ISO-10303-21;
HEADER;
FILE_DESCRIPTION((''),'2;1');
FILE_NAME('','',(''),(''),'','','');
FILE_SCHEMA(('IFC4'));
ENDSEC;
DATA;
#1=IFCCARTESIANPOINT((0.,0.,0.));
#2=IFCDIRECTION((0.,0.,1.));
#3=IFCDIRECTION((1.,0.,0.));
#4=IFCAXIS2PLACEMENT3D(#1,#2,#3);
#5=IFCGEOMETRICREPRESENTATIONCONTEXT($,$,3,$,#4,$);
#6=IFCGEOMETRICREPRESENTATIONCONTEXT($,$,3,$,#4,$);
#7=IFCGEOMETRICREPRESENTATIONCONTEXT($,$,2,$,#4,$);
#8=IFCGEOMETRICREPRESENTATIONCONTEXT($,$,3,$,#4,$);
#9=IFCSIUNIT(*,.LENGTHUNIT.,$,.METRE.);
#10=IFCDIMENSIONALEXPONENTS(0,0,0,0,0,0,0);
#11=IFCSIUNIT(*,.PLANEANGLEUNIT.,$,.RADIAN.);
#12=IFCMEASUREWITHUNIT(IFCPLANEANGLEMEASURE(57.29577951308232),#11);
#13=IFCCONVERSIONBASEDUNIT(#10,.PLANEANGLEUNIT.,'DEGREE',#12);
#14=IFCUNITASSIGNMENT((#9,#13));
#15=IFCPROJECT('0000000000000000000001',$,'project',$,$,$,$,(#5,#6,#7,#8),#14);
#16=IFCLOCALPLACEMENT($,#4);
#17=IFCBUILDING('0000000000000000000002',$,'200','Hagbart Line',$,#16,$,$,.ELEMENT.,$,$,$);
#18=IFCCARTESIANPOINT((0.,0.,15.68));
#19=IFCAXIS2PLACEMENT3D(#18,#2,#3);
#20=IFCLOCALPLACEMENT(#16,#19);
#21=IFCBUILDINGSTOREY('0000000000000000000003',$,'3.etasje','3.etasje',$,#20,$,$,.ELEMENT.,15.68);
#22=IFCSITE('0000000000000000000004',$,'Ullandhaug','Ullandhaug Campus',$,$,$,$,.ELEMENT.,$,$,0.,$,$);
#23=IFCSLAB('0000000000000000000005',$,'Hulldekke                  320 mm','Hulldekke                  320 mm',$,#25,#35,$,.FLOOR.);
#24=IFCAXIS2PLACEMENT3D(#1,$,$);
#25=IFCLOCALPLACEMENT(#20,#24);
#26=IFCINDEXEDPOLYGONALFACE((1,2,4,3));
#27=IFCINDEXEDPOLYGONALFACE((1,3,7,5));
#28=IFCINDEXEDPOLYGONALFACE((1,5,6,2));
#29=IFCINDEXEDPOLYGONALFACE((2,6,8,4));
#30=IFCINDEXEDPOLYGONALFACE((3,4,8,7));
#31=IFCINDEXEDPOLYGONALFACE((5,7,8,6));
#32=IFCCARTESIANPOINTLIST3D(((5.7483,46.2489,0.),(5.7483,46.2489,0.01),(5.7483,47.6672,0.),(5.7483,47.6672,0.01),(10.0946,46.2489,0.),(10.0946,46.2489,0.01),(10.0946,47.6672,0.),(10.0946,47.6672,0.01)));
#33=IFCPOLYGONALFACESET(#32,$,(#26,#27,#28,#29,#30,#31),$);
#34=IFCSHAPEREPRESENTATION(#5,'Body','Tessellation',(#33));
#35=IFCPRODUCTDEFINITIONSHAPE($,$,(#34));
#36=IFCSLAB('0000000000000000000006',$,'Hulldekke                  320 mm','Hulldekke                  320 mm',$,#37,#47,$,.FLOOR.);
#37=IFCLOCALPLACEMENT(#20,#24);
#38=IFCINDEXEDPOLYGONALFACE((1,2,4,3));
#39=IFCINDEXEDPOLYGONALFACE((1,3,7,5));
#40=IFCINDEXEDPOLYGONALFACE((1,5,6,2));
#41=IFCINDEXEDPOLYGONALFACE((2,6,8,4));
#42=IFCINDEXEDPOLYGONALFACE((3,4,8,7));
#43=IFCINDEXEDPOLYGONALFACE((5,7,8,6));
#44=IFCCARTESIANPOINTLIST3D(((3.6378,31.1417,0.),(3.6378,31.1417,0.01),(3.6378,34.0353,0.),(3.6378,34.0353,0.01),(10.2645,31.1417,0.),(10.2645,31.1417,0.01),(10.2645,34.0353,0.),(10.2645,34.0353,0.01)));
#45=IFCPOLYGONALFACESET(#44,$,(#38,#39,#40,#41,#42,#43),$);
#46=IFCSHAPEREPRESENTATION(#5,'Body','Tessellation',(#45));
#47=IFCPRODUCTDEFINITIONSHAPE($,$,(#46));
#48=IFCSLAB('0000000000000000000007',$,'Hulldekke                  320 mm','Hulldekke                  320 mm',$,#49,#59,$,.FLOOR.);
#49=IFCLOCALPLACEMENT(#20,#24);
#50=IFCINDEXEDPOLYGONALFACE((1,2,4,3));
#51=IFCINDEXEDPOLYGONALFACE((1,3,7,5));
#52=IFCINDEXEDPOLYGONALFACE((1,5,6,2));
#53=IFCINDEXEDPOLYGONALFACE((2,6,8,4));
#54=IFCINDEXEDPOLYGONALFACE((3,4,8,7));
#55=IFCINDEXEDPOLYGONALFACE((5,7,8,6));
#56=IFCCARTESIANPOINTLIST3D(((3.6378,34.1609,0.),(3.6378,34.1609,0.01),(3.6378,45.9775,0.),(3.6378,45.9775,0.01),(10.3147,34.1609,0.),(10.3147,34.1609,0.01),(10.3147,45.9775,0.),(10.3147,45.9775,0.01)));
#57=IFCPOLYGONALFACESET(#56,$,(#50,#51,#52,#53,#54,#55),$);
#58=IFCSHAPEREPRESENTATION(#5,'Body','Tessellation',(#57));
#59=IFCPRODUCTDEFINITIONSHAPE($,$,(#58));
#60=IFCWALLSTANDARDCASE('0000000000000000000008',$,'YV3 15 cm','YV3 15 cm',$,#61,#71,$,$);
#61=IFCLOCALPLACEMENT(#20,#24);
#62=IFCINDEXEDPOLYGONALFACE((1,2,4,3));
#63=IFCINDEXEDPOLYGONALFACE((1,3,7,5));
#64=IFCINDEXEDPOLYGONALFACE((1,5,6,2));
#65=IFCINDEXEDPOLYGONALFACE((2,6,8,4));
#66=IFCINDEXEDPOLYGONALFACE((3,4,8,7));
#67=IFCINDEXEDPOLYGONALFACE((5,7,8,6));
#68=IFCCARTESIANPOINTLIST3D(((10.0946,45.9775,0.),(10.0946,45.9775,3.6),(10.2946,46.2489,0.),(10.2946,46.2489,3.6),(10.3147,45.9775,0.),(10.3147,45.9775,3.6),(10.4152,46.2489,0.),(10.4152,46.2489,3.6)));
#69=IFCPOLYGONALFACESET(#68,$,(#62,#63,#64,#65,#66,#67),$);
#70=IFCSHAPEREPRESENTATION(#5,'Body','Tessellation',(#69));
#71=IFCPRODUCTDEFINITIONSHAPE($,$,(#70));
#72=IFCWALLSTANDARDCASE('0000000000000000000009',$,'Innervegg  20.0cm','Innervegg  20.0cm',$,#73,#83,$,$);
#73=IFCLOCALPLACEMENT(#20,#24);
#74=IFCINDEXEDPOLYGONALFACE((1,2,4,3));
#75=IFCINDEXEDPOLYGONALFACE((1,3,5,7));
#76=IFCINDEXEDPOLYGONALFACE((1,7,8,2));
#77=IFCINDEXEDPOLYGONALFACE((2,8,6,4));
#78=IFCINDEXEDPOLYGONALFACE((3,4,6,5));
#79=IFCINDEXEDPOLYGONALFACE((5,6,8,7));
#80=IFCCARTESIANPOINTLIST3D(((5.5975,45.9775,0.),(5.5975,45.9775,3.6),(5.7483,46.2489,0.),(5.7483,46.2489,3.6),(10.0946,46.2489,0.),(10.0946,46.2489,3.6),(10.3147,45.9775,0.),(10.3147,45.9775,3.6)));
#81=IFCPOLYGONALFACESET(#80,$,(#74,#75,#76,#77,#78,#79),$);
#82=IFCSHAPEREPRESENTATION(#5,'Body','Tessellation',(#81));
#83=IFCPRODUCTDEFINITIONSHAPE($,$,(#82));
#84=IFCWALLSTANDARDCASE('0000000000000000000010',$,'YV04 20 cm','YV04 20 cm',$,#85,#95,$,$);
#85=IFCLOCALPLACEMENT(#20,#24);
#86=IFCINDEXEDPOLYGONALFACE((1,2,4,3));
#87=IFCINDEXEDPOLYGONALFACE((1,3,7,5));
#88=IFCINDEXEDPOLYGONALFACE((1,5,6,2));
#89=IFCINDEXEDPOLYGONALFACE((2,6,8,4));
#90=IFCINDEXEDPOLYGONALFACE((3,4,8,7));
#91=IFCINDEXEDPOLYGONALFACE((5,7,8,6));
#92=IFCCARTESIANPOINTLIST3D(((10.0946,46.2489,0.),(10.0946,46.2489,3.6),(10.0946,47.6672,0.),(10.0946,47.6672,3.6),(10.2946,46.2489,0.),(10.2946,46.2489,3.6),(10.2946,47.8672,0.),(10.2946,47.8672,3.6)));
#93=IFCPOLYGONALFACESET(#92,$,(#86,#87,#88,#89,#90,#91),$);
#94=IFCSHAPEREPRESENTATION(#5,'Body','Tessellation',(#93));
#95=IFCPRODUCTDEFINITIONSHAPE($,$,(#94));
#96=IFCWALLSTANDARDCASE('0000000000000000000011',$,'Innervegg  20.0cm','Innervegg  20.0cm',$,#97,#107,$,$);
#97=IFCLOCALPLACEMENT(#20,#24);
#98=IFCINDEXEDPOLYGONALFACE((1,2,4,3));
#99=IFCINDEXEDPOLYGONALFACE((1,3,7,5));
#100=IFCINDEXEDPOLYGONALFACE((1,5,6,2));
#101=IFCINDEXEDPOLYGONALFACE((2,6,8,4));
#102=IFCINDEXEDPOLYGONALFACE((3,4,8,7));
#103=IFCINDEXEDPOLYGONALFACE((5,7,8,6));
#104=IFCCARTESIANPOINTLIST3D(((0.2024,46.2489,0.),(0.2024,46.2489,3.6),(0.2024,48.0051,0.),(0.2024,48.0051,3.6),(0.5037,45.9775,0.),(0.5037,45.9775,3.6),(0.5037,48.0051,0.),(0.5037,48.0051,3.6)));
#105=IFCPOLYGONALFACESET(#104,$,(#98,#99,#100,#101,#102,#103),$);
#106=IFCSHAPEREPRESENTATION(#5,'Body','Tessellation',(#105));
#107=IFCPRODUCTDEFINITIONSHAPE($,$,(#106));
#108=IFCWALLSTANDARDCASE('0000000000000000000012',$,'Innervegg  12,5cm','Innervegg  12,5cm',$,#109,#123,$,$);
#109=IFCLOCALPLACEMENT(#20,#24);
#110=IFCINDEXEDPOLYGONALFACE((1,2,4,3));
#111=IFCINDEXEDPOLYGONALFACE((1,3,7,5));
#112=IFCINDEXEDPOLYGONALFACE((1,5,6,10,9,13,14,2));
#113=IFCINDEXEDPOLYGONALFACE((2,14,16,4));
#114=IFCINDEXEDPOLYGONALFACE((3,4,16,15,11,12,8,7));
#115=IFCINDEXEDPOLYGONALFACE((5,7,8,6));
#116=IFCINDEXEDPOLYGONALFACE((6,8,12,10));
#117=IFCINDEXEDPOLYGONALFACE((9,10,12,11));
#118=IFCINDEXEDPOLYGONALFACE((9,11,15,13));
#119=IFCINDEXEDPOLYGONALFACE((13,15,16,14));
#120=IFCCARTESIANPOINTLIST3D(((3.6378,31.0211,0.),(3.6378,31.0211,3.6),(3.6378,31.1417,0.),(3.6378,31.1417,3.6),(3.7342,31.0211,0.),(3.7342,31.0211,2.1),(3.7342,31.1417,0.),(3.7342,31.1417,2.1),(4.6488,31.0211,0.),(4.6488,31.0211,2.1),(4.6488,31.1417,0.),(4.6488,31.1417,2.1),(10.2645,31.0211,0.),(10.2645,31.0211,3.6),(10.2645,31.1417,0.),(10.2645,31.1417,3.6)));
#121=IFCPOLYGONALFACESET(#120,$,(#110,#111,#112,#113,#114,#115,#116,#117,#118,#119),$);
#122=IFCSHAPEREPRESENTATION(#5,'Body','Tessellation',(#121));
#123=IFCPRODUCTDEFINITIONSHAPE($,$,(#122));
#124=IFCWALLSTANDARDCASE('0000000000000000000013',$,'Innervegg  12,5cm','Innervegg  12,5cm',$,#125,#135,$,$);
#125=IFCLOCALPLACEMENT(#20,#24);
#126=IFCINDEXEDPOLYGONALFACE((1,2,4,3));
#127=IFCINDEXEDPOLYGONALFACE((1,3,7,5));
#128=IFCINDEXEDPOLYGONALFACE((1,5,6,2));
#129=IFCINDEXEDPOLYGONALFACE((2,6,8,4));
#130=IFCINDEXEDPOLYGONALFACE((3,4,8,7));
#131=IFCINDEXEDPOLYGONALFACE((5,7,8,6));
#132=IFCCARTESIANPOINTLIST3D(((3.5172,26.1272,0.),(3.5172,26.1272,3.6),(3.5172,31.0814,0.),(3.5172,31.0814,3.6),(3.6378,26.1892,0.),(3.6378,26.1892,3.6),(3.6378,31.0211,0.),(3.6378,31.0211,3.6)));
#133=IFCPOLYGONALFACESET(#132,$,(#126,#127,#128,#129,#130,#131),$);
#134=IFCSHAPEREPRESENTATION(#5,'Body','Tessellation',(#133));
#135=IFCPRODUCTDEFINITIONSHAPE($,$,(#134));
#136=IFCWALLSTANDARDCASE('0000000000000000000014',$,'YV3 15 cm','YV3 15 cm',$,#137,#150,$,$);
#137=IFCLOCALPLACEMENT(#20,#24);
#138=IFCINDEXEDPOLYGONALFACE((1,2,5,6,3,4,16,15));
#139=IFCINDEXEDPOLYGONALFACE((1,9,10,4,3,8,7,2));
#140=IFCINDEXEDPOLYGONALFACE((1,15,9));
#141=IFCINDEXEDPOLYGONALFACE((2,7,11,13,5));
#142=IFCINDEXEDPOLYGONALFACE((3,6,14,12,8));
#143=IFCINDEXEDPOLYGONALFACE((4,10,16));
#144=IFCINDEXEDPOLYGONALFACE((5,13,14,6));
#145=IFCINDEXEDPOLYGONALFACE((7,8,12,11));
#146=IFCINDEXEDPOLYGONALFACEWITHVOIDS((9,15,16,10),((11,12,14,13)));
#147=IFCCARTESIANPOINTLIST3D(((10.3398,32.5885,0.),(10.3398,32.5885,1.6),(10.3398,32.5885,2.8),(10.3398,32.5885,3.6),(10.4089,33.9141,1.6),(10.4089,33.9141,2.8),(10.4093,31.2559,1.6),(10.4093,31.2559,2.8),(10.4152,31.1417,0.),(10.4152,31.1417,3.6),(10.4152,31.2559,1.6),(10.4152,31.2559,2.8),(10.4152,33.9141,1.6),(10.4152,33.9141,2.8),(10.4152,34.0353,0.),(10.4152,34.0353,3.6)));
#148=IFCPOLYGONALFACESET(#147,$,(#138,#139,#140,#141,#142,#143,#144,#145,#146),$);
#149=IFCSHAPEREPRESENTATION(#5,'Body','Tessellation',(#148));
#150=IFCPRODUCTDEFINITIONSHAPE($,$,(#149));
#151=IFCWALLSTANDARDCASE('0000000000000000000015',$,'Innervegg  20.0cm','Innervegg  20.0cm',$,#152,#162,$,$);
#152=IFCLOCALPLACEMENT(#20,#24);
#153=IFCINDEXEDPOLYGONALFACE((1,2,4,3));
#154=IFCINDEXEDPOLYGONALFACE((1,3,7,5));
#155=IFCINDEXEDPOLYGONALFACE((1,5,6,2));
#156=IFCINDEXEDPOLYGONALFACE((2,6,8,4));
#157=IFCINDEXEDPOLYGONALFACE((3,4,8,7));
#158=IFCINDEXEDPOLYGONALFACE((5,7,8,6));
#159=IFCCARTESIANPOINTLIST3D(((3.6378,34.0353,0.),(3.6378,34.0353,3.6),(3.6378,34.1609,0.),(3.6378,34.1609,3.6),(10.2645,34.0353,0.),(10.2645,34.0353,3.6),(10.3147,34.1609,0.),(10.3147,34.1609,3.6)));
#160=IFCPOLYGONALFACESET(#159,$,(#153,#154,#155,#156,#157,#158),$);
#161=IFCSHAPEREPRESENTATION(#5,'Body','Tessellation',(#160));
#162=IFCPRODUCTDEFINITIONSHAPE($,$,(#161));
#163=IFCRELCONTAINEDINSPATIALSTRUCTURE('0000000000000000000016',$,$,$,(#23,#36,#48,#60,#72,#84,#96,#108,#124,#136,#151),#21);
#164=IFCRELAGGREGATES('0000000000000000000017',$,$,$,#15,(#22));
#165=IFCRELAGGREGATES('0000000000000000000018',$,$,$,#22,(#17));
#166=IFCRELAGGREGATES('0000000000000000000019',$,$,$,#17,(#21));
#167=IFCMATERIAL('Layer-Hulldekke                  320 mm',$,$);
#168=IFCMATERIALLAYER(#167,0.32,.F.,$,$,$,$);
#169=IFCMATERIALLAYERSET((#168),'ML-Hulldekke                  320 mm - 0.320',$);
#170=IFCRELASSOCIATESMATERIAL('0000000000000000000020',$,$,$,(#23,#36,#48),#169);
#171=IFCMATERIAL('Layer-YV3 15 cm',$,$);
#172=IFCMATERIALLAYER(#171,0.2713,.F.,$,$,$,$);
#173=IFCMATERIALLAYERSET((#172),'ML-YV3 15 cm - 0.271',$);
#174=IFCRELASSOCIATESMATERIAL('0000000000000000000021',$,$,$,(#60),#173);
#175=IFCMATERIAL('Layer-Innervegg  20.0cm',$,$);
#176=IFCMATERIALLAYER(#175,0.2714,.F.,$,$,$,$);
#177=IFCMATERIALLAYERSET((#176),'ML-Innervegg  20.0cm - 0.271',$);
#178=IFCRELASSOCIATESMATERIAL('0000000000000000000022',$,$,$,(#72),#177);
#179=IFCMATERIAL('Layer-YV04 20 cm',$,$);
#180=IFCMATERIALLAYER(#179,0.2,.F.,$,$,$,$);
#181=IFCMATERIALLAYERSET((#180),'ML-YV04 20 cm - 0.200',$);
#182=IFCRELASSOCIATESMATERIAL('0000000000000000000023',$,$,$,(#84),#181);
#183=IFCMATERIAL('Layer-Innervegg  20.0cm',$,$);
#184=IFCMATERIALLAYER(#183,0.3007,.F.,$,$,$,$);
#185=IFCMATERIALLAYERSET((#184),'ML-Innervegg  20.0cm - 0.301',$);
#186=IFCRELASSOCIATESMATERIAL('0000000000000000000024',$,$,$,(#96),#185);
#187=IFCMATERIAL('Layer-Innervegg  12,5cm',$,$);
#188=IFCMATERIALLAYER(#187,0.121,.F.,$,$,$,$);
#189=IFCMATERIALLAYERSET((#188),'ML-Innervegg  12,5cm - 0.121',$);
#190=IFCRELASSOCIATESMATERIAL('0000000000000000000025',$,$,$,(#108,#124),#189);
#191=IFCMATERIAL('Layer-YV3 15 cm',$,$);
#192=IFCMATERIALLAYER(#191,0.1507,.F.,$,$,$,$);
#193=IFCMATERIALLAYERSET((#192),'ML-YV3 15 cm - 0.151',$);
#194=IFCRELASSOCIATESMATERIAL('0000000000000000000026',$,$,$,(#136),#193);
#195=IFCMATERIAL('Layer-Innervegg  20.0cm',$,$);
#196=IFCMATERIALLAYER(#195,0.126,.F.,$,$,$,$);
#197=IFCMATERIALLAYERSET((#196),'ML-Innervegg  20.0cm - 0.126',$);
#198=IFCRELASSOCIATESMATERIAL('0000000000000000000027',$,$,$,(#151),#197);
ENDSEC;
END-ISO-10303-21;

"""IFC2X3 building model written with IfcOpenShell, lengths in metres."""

from ifc_helpers import new_model, entity, si_unit, converted_unit, frame, origin_with_axes, place, context, project, spatial, polyline, outline, extrude, material, layer, layer_set, layer_usage, element, save


model = new_model("IFC2X3")

# Units and contexts
context_of_model_1 = context(None, 3, world=origin_with_axes())
context_of_model_2 = context(None, 3, world=origin_with_axes())
context_of_model_3 = context(None, 2, world=origin_with_axes())
context_of_model_4 = context(None, 3, world=origin_with_axes())
ifc_project = project(units=[si_unit("LENGTHUNIT", "METRE"), converted_unit("PLANEANGLEUNIT", "DEGREE", entity("IfcPlaneAngleMeasure", 57.29577951308232), si_unit("PLANEANGLEUNIT", "RADIAN"), dimensions=[0, 0, 0, 0, 0, 0, 0])], contexts=[context_of_model_1, context_of_model_2, context_of_model_3, context_of_model_4])

# Site, building, storey
site = spatial("IfcSite", under=ifc_project, Name="Ullandhaug", Description="Ullandhaug Campus", CompositionType="ELEMENT", RefElevation=0.0)
building_placement = place(None, origin_with_axes())
building = spatial("IfcBuilding", under=site, at=building_placement, Name="200", Description="Hagbart Line", CompositionType="ELEMENT")
storey_placement = place(building_placement, frame((0.0, 0.0, 15.68), z_axis=(0.0, 0.0, 1.0), x_axis=(1.0, 0.0, 0.0)))
storey = spatial("IfcBuildingStorey", under=building, at=storey_placement, Name="3.etasje", Description="3.etasje", CompositionType="ELEMENT", Elevation=15.68)

# Slabs
ifc_material_1 = material(Name="Layer-Hulldekke                  320 mm")
ifc_layer_1 = layer(ifc_material_1, 0.32, ventilated=False)
ifc_layer_set_1 = layer_set([ifc_layer_1], Name="ML-Hulldekke                  320 mm - 0.320")
ifc_layer_usage_1 = layer_usage(ifc_layer_set_1, "AXIS2", "POSITIVE", 0.0)
slab_1_placement = place(storey_placement, frame((5.7483, 46.2489, 0.0), z_axis=(0.0, 0.0, 1.0), x_axis=(1.0, 0.0, 0.0)))
element("IfcSlab", 1, at=slab_1_placement, inside=storey, material=ifc_layer_usage_1, Name="Hulldekke                  320 mm", Description="Hulldekke                  320 mm", PredefinedType="FLOOR", context=context_of_model_1, shape_type="SweptSolid", body=[
    extrude(outline(polyline([(0.0, 0.0), (4.3463, 0.0), (4.3463, 1.4184), (0.0, 1.4184), (0.0, 0.0)])), origin_with_axes(), (0.0, 0.0, 1.0), 0.01),
])
slab_2_placement = place(storey_placement, frame((3.6378, 31.1417, 0.0), z_axis=(0.0, 0.0, 1.0), x_axis=(1.0, 0.0, 0.0)))
element("IfcSlab", 2, at=slab_2_placement, inside=storey, material=ifc_layer_usage_1, Name="Hulldekke                  320 mm", Description="Hulldekke                  320 mm", PredefinedType="FLOOR", context=context_of_model_1, shape_type="SweptSolid", body=[
    extrude(outline(polyline([(0.0, 0.0), (6.6267, 0.0), (6.6267, 2.8936), (0.0, 2.8936), (0.0, 0.0)])), origin_with_axes(), (0.0, 0.0, 1.0), 0.01),
])
slab_3_placement = place(storey_placement, frame((3.6378, 34.1609, 0.0), z_axis=(0.0, 0.0, 1.0), x_axis=(1.0, 0.0, 0.0)))
element("IfcSlab", 3, at=slab_3_placement, inside=storey, material=ifc_layer_usage_1, Name="Hulldekke                  320 mm", Description="Hulldekke                  320 mm", PredefinedType="FLOOR", context=context_of_model_1, shape_type="SweptSolid", body=[
    extrude(outline(polyline([(0.0, 0.0), (6.6769, 0.0), (6.6769, 11.8166), (0.0, 11.8166), (0.0, 0.0)])), origin_with_axes(), (0.0, 0.0, 1.0), 0.01),
])

# Walls
ifc_material_2 = material(Name="Layer-YV3 15 cm")
ifc_layer_2 = layer(ifc_material_2, 0.2713, ventilated=False)
ifc_layer_set_2 = layer_set([ifc_layer_2], Name="ML-YV3 15 cm - 0.271")
ifc_layer_usage_2 = layer_usage(ifc_layer_set_2, "AXIS2", "POSITIVE", 0.0)
wall_1_placement = place(storey_placement, frame((10.4152, 46.2489, 0.0), z_axis=(0.0, 0.0, 1.0), x_axis=(-1.0, 0.0, 0.0)))
element("IfcWallStandardCase", 4, at=wall_1_placement, inside=storey, material=ifc_layer_usage_2, Name="YV3 15 cm", Description="YV3 15 cm", context=context_of_model_1, shape_type="SweptSolid", body=[
    extrude(outline(polyline([(0.0, 0.0), (0.1206, 0.0), (0.3206, 0.2713), (0.1005, 0.2713), (0.0, 0.0)])), frame((0.0, 0.0, 0.0), z_axis=(0.0, 0.0, 1.0), x_axis=(1.0, 0.0, 0.0)), (0.0, 0.0, 1.0), 3.6),
])
ifc_material_3 = material(Name="Layer-Innervegg  20.0cm")
ifc_layer_3 = layer(ifc_material_3, 0.2714, ventilated=False)
ifc_layer_set_3 = layer_set([ifc_layer_3], Name="ML-Innervegg  20.0cm - 0.271")
ifc_layer_usage_3 = layer_usage(ifc_layer_set_3, "AXIS2", "POSITIVE", 0.0)
wall_2_placement = place(storey_placement, frame((5.5975, 45.9775, 0.0), z_axis=(0.0, 0.0, 1.0), x_axis=(1.0, 0.0, 0.0)))
element("IfcWallStandardCase", 5, at=wall_2_placement, inside=storey, material=ifc_layer_usage_3, Name="Innervegg  20.0cm", Description="Innervegg  20.0cm", context=context_of_model_1, shape_type="SweptSolid", body=[
    extrude(outline(polyline([(0.0, 0.0), (4.7172, 0.0), (4.4971, 0.2713), (0.1508, 0.2713), (0.0, 0.0)])), origin_with_axes(), (0.0, 0.0, 1.0), 3.6),
])
ifc_material_4 = material(Name="Layer-YV04 20 cm")
ifc_layer_4 = layer(ifc_material_4, 0.2, ventilated=False)
ifc_layer_set_4 = layer_set([ifc_layer_4], Name="ML-YV04 20 cm - 0.200")
ifc_layer_usage_4 = layer_usage(ifc_layer_set_4, "AXIS2", "POSITIVE", 0.0)
wall_3_placement = place(storey_placement, frame((10.2946, 46.2489, 0.0), z_axis=(0.0, 0.0, 1.0), x_axis=(0.0, 1.0, 0.0)))
element("IfcWallStandardCase", 6, at=wall_3_placement, inside=storey, material=ifc_layer_usage_4, Name="YV04 20 cm", Description="YV04 20 cm", context=context_of_model_1, shape_type="SweptSolid", body=[
    extrude(outline(polyline([(0.0, 0.0), (1.6184, 0.0), (1.4184, 0.2), (0.0, 0.2), (0.0, 0.0)])), frame((0.0, 0.0, 0.0), z_axis=(0.0, 0.0, 1.0), x_axis=(1.0, 0.0, 0.0)), (0.0, 0.0, 1.0), 3.6),
])
ifc_material_5 = material(Name="Layer-Innervegg  20.0cm")
ifc_layer_5 = layer(ifc_material_5, 0.3007, ventilated=False)
ifc_layer_set_5 = layer_set([ifc_layer_5], Name="ML-Innervegg  20.0cm - 0.301")
ifc_layer_usage_5 = layer_usage(ifc_layer_set_5, "AXIS2", "POSITIVE", 0.0)
wall_4_placement = place(storey_placement, frame((0.5037, 45.9775, 0.0), z_axis=(0.0, 0.0, 1.0), x_axis=(0.0, 1.0, 0.0)))
element("IfcWallStandardCase", 7, at=wall_4_placement, inside=storey, material=ifc_layer_usage_5, Name="Innervegg  20.0cm", Description="Innervegg  20.0cm", context=context_of_model_1, shape_type="SweptSolid", body=[
    extrude(outline(polyline([(0.0, 0.0), (2.0276, 0.0), (2.0276, 0.3013), (0.2713, 0.3013), (0.0, 0.0)])), frame((0.0, 0.0, 0.0), z_axis=(0.0, 0.0, 1.0), x_axis=(1.0, 0.0, 0.0)), (0.0, 0.0, 1.0), 3.6),
])

# Wall, opening
ifc_material_6 = material(Name="Layer-Innervegg  12,5cm")
ifc_layer_6 = layer(ifc_material_6, 0.121, ventilated=False)
ifc_layer_set_6 = layer_set([ifc_layer_6], Name="ML-Innervegg  12,5cm - 0.121")
ifc_layer_usage_6 = layer_usage(ifc_layer_set_6, "AXIS2", "POSITIVE", 0.0)
wall_5_placement = place(storey_placement, frame((10.2645, 31.1417, 0.0), z_axis=(0.0, 0.0, 1.0), x_axis=(-1.0, 0.0, 0.0)))
wall_5 = element("IfcWallStandardCase", 8, at=wall_5_placement, inside=storey, material=ifc_layer_usage_6, Name="Innervegg  12,5cm", Description="Innervegg  12,5cm", context=context_of_model_1, shape_type="SweptSolid", body=[
    extrude(outline(polyline([(0.0, 0.0), (6.6267, 0.0), (6.6267, 0.1206), (0.0, 0.1206), (0.0, 0.0)])), frame((0.0, 0.0, 0.0), z_axis=(0.0, 0.0, 1.0), x_axis=(1.0, 0.0, 0.0)), (0.0, 0.0, 1.0), 3.6),
])
opening_1_placement = place(wall_5_placement, frame((5.6157, 0.1206, 0.0), z_axis=(0.0, 0.0, 1.0), x_axis=(1.0, 0.0, 0.0)))
element("IfcOpeningElement", 9, at=opening_1_placement, cuts=wall_5, context=context_of_model_1, shape_type="SweptSolid", body=[
    extrude(outline(polyline([(0.0, 0.0), (2.1, 0.0), (2.1, 0.9146), (0.0, 0.9146), (0.0, 0.0)])), frame((0.0, 0.0, 0.0), z_axis=(0.0, 1.0, 0.0), x_axis=(0.0, 0.0, 1.0)), (0.0, 0.0, -1.0), 0.1206),
])

# Wall
wall_6_placement = place(storey_placement, frame((3.5172, 31.0814, 0.0), z_axis=(0.0, 0.0, 1.0), x_axis=(0.0, -1.0, 0.0)))
element("IfcWallStandardCase", 10, at=wall_6_placement, inside=storey, material=ifc_layer_usage_6, Name="Innervegg  12,5cm", Description="Innervegg  12,5cm", context=context_of_model_1, shape_type="SweptSolid", body=[
    extrude(outline(polyline([(0.0, 0.0), (4.9541, 0.0), (4.8921, 0.1206), (0.0603, 0.1206), (0.0, 0.0)])), frame((0.0, 0.0, 0.0), z_axis=(0.0, 0.0, 1.0), x_axis=(1.0, 0.0, 0.0)), (0.0, 0.0, 1.0), 3.6),
])

# Wall, opening
ifc_material_7 = material(Name="Layer-YV3 15 cm")
ifc_layer_7 = layer(ifc_material_7, 0.1507, ventilated=False)
ifc_layer_set_7 = layer_set([ifc_layer_7], Name="ML-YV3 15 cm - 0.151")
ifc_layer_usage_7 = layer_usage(ifc_layer_set_7, "AXIS2", "POSITIVE", 0.0)
wall_7_placement = place(storey_placement, frame((10.2645, 31.1417, 0.0), z_axis=(0.0, 0.0, 1.0), x_axis=(0.0, 1.0, 0.0)))
wall_7 = element("IfcWallStandardCase", 11, at=wall_7_placement, inside=storey, material=ifc_layer_usage_7, Name="YV3 15 cm", Description="YV3 15 cm", context=context_of_model_1, shape_type="SweptSolid", body=[
    extrude(outline(polyline([(0.0, 0.0), (2.8936, 0.0), (0.0, 0.1507), (2.8936, 0.1507), (0.0, 0.0)])), frame((0.0, 0.0, 0.0), z_axis=(0.0, 0.0, -1.0), x_axis=(1.0, 0.0, 0.0)), (0.0, 0.0, -1.0), 3.6),
])
opening_2_placement = place(wall_7_placement, frame((0.1142, 0.0, 1.6), z_axis=(0.0, 0.0, 1.0), x_axis=(1.0, 0.0, 0.0)))
element("IfcOpeningElement", 12, at=opening_2_placement, cuts=wall_7, context=context_of_model_1, shape_type="SweptSolid", body=[
    extrude(outline(polyline([(0.0, 0.0), (1.2, 0.0), (1.2, 2.6582), (0.0, 2.6582), (0.0, 0.0)])), frame((0.0, 0.0, 0.0), z_axis=(0.0, 1.0, 0.0), x_axis=(0.0, 0.0, 1.0)), (0.0, 0.0, -1.0), 0.1507),
])

# Wall
ifc_material_8 = material(Name="Layer-Innervegg  20.0cm")
ifc_layer_8 = layer(ifc_material_8, 0.126, ventilated=False)
ifc_layer_set_8 = layer_set([ifc_layer_8], Name="ML-Innervegg  20.0cm - 0.126")
ifc_layer_usage_8 = layer_usage(ifc_layer_set_8, "AXIS2", "POSITIVE", 0.0)
wall_8_placement = place(storey_placement, frame((10.3147, 34.1609, 0.0), z_axis=(0.0, 0.0, 1.0), x_axis=(-1.0, 0.0, 0.0)))
element("IfcWallStandardCase", 13, at=wall_8_placement, inside=storey, material=ifc_layer_usage_8, Name="Innervegg  20.0cm", Description="Innervegg  20.0cm", context=context_of_model_1, shape_type="SweptSolid", body=[
    extrude(outline(polyline([(0.0, 0.0), (6.6769, 0.0), (6.6769, 0.1256), (0.0503, 0.1256), (0.0, 0.0)])), frame((0.0, 0.0, 0.0), z_axis=(0.0, 0.0, 1.0), x_axis=(1.0, 0.0, 0.0)), (0.0, 0.0, 1.0), 3.6),
])

save(model, "model.ifc")
